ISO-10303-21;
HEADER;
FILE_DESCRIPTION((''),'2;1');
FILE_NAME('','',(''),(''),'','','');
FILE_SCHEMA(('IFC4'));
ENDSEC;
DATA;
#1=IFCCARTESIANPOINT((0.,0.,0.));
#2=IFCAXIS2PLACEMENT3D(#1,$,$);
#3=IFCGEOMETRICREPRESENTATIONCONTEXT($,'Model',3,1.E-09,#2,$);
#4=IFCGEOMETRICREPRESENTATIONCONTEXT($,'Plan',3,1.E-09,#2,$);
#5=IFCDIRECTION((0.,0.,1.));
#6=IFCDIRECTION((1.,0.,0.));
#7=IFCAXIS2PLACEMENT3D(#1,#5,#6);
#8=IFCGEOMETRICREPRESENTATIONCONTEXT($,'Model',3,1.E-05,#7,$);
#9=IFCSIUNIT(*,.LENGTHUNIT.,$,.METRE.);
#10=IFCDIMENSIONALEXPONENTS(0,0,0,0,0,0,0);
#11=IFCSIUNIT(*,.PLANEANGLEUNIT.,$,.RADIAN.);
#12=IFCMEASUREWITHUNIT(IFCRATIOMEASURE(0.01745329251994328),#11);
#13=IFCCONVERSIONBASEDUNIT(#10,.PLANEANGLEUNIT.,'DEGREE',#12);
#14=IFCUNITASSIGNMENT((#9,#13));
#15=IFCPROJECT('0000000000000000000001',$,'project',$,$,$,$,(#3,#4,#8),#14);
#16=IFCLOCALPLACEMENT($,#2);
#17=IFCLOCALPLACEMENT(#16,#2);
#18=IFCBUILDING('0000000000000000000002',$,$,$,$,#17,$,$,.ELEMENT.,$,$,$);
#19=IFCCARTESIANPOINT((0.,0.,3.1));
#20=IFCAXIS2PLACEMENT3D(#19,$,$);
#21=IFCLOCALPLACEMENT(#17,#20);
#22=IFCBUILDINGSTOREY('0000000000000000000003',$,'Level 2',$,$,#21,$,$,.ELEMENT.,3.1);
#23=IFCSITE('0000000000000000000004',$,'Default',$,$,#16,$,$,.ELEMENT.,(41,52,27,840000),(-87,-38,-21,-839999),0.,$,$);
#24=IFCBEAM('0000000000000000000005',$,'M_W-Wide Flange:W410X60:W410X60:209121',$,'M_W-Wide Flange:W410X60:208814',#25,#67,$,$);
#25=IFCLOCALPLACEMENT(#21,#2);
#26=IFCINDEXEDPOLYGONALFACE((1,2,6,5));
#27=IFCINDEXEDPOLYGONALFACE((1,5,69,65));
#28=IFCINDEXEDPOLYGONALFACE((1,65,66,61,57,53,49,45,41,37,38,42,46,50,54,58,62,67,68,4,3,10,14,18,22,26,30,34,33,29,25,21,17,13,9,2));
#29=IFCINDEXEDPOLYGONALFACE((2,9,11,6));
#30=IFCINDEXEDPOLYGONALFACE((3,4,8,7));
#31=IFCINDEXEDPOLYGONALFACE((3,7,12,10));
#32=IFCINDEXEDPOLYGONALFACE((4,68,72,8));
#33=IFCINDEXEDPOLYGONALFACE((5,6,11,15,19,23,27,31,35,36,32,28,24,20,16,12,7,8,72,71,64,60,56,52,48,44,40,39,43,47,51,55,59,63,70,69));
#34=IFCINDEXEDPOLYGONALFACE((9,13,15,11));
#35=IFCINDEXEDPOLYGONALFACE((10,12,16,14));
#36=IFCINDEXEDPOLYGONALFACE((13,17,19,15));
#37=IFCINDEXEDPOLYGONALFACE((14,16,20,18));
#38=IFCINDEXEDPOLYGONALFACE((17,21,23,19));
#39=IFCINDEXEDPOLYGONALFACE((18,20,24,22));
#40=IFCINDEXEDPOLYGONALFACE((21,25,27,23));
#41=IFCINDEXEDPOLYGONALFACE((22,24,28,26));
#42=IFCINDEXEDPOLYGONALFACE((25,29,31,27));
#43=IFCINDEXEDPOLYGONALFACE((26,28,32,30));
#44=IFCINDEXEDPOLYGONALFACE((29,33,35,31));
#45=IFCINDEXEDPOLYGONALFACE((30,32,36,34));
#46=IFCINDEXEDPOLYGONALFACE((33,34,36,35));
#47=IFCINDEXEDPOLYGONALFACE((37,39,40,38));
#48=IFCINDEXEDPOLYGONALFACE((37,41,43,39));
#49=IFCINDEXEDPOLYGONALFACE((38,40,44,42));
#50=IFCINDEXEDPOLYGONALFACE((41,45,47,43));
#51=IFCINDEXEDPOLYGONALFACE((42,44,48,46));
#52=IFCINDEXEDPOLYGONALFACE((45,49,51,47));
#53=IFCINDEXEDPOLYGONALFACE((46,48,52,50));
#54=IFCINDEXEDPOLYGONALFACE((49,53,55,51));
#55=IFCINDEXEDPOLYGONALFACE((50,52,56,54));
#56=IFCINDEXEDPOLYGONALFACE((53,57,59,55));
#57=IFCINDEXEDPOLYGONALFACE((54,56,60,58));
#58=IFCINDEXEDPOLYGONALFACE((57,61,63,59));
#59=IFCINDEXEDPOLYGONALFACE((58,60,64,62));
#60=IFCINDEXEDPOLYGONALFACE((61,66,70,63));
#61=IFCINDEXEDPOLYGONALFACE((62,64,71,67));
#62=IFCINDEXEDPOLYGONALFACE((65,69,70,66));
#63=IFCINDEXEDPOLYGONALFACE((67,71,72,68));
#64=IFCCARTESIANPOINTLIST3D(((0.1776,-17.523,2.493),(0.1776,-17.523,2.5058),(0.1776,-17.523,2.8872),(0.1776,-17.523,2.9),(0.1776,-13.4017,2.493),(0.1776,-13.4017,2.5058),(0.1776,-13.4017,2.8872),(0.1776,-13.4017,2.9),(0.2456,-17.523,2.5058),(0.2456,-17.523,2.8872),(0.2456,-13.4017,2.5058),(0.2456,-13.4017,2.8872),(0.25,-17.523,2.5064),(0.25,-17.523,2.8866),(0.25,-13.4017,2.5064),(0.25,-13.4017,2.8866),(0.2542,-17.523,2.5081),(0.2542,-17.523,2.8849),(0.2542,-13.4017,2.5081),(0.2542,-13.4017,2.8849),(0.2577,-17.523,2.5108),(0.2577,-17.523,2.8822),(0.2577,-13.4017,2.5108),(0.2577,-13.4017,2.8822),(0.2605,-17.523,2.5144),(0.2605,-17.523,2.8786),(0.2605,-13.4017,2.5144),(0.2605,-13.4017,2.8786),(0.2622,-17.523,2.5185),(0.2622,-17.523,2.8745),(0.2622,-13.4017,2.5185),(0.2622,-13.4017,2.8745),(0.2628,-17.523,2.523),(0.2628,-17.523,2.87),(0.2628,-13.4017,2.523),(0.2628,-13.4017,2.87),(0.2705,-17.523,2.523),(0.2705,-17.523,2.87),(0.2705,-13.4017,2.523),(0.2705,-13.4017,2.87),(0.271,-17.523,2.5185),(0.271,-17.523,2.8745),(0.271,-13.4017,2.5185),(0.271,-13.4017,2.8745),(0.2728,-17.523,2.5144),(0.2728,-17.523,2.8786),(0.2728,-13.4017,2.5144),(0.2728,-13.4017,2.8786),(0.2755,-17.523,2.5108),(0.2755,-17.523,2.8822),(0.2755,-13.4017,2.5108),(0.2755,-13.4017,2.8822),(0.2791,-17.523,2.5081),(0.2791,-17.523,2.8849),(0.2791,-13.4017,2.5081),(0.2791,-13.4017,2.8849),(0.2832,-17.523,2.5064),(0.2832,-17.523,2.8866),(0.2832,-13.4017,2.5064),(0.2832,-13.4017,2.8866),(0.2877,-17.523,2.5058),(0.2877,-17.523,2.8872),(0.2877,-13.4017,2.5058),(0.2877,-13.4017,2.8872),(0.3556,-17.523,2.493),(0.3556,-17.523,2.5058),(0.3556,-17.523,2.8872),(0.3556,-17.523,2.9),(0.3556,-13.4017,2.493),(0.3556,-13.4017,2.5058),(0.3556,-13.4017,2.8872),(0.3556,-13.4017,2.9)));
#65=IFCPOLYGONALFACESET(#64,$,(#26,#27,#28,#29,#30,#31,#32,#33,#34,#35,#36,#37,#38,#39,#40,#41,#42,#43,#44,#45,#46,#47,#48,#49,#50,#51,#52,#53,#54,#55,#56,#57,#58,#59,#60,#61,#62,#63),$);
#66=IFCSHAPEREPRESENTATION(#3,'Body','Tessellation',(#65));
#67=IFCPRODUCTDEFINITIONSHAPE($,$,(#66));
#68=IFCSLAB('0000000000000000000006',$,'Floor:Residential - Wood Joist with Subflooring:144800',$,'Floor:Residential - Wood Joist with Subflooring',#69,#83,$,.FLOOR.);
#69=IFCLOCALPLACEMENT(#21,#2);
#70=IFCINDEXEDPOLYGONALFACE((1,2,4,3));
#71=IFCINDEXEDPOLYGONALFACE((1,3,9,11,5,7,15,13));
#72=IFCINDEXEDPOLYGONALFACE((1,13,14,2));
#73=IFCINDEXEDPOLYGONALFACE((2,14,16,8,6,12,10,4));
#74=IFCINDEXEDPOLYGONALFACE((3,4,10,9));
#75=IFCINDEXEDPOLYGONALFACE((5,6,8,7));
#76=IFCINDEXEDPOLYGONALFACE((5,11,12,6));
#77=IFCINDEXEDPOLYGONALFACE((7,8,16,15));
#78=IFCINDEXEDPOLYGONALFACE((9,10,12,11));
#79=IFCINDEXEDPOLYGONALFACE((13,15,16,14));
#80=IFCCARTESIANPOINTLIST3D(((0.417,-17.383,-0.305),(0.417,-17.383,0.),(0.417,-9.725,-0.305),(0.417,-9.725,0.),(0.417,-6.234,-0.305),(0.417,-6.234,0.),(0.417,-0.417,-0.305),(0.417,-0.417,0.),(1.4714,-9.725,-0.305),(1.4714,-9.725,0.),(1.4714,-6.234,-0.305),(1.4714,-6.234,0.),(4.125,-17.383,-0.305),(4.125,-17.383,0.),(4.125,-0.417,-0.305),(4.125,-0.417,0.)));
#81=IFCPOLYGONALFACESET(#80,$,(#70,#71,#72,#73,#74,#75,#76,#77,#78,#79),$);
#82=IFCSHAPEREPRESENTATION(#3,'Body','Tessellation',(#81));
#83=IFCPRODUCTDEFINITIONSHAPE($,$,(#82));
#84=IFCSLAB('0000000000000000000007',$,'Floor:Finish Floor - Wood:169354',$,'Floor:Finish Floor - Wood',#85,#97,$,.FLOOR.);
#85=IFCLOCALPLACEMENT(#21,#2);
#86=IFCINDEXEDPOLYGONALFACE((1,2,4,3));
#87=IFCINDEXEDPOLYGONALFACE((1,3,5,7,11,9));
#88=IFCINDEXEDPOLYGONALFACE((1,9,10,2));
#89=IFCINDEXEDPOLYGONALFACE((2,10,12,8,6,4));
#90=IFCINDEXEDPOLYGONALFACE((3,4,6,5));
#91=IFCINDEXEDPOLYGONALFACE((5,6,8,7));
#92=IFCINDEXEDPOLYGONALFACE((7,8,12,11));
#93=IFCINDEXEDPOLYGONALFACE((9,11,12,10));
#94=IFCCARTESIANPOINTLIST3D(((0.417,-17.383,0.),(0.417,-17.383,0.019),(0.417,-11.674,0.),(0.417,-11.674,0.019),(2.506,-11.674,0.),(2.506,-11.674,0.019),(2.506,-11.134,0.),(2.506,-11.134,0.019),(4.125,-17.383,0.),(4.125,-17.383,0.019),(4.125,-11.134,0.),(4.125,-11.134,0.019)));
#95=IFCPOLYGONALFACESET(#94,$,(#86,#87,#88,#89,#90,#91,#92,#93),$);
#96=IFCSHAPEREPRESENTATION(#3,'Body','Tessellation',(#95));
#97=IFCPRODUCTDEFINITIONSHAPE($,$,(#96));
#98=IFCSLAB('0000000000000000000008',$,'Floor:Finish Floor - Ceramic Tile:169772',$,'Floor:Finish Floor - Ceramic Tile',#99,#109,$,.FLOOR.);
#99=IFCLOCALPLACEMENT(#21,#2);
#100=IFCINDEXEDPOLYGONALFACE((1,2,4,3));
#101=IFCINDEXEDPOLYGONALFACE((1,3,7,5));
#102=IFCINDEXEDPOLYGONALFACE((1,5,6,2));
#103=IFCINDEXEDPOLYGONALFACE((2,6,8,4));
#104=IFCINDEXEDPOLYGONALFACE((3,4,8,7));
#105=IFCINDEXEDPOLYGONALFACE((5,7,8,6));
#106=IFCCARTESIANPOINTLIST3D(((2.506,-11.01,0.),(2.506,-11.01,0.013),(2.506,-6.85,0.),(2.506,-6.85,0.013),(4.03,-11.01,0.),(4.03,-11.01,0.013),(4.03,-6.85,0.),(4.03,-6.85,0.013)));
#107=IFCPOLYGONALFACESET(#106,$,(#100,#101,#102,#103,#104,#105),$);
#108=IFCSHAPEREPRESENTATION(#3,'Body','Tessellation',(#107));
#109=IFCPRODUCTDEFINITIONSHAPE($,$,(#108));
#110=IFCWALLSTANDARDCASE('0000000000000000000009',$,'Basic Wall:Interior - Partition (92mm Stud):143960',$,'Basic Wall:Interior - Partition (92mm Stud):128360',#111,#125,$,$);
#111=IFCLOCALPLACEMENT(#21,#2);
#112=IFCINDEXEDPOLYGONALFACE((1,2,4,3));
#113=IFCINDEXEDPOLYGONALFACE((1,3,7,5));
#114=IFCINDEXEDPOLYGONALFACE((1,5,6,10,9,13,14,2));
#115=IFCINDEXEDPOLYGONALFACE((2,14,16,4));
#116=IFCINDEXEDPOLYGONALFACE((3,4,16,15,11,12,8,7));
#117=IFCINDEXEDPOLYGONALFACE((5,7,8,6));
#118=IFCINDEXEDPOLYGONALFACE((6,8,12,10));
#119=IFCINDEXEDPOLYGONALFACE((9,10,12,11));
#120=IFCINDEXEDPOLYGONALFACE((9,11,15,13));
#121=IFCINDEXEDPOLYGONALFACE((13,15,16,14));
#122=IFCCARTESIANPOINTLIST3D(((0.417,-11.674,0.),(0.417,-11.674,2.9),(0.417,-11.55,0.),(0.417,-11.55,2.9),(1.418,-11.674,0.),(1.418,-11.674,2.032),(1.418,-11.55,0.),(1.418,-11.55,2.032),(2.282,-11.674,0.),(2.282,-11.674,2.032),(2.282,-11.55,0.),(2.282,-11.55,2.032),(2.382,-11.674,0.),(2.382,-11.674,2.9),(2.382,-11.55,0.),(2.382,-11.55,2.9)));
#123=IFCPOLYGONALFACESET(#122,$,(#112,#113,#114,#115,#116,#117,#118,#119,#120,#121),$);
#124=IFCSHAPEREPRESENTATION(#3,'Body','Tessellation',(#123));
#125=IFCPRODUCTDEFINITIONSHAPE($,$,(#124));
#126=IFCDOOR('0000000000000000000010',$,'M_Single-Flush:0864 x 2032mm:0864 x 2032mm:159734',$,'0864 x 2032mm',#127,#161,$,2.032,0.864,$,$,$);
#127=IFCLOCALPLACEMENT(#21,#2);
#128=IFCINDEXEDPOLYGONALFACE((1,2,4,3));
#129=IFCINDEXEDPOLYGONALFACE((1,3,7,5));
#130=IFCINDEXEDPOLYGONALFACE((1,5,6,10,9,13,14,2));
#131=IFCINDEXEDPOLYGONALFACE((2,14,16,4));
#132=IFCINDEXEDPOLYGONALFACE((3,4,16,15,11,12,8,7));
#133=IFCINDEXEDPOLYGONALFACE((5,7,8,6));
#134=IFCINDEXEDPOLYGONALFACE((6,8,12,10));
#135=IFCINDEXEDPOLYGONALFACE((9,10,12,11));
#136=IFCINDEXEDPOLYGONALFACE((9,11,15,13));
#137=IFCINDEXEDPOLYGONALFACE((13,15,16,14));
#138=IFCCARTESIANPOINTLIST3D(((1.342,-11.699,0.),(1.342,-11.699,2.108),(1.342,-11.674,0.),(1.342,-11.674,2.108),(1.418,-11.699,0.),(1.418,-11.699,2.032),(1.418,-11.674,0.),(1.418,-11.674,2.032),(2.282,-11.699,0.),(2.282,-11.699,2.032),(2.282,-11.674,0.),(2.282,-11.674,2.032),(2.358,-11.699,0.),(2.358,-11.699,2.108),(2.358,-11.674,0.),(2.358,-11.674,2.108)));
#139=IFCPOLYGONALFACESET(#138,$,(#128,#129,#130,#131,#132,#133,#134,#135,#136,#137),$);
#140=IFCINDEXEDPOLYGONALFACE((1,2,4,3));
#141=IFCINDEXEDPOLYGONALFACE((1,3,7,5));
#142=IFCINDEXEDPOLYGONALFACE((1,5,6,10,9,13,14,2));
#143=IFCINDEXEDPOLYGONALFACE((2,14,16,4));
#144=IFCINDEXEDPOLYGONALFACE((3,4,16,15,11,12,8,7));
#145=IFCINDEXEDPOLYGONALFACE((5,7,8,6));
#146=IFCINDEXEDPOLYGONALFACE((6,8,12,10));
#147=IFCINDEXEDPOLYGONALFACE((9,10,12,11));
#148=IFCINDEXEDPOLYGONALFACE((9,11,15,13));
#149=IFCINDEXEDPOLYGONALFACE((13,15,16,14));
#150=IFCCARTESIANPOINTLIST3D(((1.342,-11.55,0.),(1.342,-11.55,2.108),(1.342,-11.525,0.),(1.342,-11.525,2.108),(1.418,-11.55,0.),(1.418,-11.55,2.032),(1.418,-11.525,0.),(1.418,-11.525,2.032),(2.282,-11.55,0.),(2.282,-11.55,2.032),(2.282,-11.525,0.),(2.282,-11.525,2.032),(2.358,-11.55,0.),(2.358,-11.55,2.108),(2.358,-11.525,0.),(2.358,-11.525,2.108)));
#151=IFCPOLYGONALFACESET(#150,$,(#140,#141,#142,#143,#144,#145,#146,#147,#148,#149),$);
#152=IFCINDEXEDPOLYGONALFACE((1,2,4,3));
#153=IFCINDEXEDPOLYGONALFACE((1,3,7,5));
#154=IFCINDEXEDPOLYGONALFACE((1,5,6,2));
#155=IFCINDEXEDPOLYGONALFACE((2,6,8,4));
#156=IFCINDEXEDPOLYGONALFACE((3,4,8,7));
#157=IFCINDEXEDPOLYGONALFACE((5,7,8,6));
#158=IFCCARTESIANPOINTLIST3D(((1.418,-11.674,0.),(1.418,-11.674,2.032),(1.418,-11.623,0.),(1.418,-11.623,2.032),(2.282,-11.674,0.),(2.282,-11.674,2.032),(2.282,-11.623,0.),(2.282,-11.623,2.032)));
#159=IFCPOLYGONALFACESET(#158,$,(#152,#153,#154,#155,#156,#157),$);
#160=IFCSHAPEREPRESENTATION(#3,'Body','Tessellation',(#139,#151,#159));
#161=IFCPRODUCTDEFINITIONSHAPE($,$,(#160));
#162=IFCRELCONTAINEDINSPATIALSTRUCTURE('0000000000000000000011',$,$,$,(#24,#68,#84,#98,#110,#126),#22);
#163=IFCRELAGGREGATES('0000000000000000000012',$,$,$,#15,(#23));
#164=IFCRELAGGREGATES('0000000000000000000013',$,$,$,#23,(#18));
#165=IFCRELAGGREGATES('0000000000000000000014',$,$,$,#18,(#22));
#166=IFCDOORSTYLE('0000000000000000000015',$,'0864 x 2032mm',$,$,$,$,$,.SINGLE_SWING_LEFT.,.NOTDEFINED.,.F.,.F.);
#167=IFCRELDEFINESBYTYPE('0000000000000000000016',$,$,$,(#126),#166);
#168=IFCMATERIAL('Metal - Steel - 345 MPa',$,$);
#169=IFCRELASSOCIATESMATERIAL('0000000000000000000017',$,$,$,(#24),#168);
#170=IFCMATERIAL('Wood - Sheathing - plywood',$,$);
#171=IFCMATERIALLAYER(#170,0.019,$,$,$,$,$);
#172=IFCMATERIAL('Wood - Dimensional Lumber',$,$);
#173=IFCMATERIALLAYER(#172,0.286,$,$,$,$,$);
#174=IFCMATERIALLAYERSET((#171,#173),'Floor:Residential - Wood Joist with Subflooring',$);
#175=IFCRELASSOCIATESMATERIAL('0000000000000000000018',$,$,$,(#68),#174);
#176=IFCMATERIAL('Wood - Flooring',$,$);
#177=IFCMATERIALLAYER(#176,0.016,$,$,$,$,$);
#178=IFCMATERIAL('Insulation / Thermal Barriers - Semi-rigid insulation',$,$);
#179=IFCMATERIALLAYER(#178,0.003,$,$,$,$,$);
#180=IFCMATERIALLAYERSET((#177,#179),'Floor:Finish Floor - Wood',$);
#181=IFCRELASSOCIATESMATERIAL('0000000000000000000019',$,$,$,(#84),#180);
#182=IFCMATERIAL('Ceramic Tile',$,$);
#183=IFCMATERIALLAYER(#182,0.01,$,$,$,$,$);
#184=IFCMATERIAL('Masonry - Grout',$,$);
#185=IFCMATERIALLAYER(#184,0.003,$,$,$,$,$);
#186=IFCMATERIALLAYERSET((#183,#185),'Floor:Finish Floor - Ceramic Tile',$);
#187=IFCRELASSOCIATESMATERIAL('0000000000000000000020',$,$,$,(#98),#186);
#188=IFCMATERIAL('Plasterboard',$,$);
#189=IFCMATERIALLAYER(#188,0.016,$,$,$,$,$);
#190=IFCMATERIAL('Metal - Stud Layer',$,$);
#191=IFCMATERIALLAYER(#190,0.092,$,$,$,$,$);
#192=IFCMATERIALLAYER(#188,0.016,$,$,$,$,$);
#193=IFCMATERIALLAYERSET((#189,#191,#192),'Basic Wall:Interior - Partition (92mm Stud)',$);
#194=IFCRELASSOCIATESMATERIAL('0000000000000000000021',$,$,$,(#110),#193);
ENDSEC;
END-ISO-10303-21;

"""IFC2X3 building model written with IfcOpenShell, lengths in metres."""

from ifc_helpers import new_model, entity, si_unit, converted_unit, frame, frame_2d, origin, origin_with_axes, origin_2d_with_axis, place, context, project, spatial, polyline, circle_curve, parameter, trimmed, segment, composite_curve, rectangle, outline, extrude, source, transform, mapped, material, layer, layer_set, layer_usage, type_object, type_shapes, element, fill, save


model = new_model("IFC2X3")

# Units and contexts
model_context_1 = context("Model", 3, precision=1e-09, world=origin())
plan_context = context("Plan", 3, precision=1e-09, world=origin())
model_context_2 = context("Model", 3, precision=1e-05, world=origin_with_axes())
ifc_project = project(units=[si_unit("LENGTHUNIT", "METRE"), converted_unit("PLANEANGLEUNIT", "DEGREE", entity("IfcRatioMeasure", 0.01745329251994328), si_unit("PLANEANGLEUNIT", "RADIAN"), dimensions=[0, 0, 0, 0, 0, 0, 0])], contexts=[model_context_1, plan_context, model_context_2])

# Site, building, storey
site_placement = place(None, origin())
site = spatial("IfcSite", under=ifc_project, at=site_placement, Name="Default", CompositionType="ELEMENT", RefLatitude=(41, 52, 27, 840000), RefLongitude=(-87, -38, -21, -839999), RefElevation=0.0)
building_placement = place(site_placement, origin())
building = spatial("IfcBuilding", under=site, at=building_placement, CompositionType="ELEMENT")
storey_placement = place(building_placement, frame((0.0, 0.0, 3.1)))
storey = spatial("IfcBuildingStorey", under=building, at=storey_placement, Name="Level 2", CompositionType="ELEMENT", Elevation=3.1)

# Beam
ifc_material_1 = material(Name="Metal - Steel - 345 MPa")
beam_placement = place(storey_placement, frame((0.2666, -13.4017, 2.9), z_axis=(0.0, 0.0, 1.0), x_axis=(-1.0, 0.0, 0.0)))
element("IfcBeam", 1, at=beam_placement, inside=storey, material=ifc_material_1, Name="M_W-Wide Flange:W410X60:W410X60:209121", ObjectType="M_W-Wide Flange:W410X60:208814", context=model_context_1, shape_type="SweptSolid", body=[
    extrude(outline(composite_curve([segment(polyline([(0.1907, -0.089), (0.2035, -0.089)]), True, "CONTINUOUS"), segment(polyline([(0.2035, -0.089), (0.2035, 0.089)]), True, "CONTINUOUS"), segment(polyline([(0.2035, 0.089), (0.1907, 0.089)]), True, "CONTINUOUS"), segment(polyline([(0.1907, 0.089), (0.1907, 0.021)]), True, "CONTINUOUS"), segment(trimmed(circle_curve(frame_2d((0.1735, 0.021), x_axis=(1.0, 0.0)), 0.0172), [parameter(270.0)], [parameter(360.0)], True, "PARAMETER"), False, "CONTINUOUS"), segment(polyline([(0.1735, 0.0038), (-0.1735, 0.0038)]), True, "CONTINUOUS"), segment(trimmed(circle_curve(frame_2d((-0.1735, 0.021), x_axis=(0.0, -1.0)), 0.0172), [parameter(270.0)], [parameter(360.0)], True, "PARAMETER"), False, "CONTINUOUS"), segment(polyline([(-0.1907, 0.021), (-0.1907, 0.089)]), True, "CONTINUOUS"), segment(polyline([(-0.1907, 0.089), (-0.2035, 0.089)]), True, "CONTINUOUS"), segment(polyline([(-0.2035, 0.089), (-0.2035, -0.089)]), True, "CONTINUOUS"), segment(polyline([(-0.2035, -0.089), (-0.1907, -0.089)]), True, "CONTINUOUS"), segment(polyline([(-0.1907, -0.089), (-0.1907, -0.0211)]), True, "CONTINUOUS"), segment(trimmed(circle_curve(frame_2d((-0.1735, -0.0211), x_axis=(-1.0, 0.0)), 0.0172), [parameter(270.0)], [parameter(0.0)], True, "PARAMETER"), False, "CONTINUOUS"), segment(polyline([(-0.1735, -0.0039), (0.1735, -0.0039)]), True, "CONTINUOUS"), segment(trimmed(circle_curve(frame_2d((0.1735, -0.0211), x_axis=(0.0, 1.0)), 0.0172), [parameter(270.0)], [parameter(0.0)], True, "PARAMETER"), False, "CONTINUOUS"), segment(polyline([(0.1907, -0.0211), (0.1907, -0.089)]), True, "CONTINUOUS")], self_intersect=False)), frame((0.0, 4.1213, -0.2035), z_axis=(0.0, -1.0, 0.0), x_axis=(0.0, 0.0, -1.0)), (0.0, 0.0, 1.0), 4.1213),
])

# Slabs
ifc_material_2 = material(Name="Wood - Sheathing - plywood")
ifc_layer_1 = layer(ifc_material_2, 0.019)
ifc_material_3 = material(Name="Wood - Dimensional Lumber")
ifc_layer_2 = layer(ifc_material_3, 0.286)
ifc_layer_set_1 = layer_set([ifc_layer_1, ifc_layer_2], Name="Floor:Residential - Wood Joist with Subflooring")
ifc_layer_usage_1 = layer_usage(ifc_layer_set_1, "AXIS3", "POSITIVE", 0.0)
slab_1_placement = place(storey_placement, frame((0.417, -17.383, -0.305)))
element("IfcSlab", 2, at=slab_1_placement, inside=storey, material=ifc_layer_usage_1, Name="Floor:Residential - Wood Joist with Subflooring:144800", ObjectType="Floor:Residential - Wood Joist with Subflooring", PredefinedType="FLOOR", context=model_context_1, shape_type="SweptSolid", body=[
    extrude(outline(polyline([(-1.854, 8.483), (-1.854, -8.483), (1.854, -8.483), (1.854, -0.825), (0.7996, -0.825), (0.7996, 2.666), (1.854, 2.666), (1.854, 8.483), (-1.854, 8.483)])), frame((1.854, 8.483, 0.305), z_axis=(0.0, 0.0, -1.0), x_axis=(-1.0, 0.0, 0.0)), (0.0, 0.0, 1.0), 0.305),
])
ifc_material_4 = material(Name="Wood - Flooring")
ifc_layer_3 = layer(ifc_material_4, 0.016)
ifc_material_5 = material(Name="Insulation / Thermal Barriers - Semi-rigid insulation")
ifc_layer_4 = layer(ifc_material_5, 0.003)
ifc_layer_set_2 = layer_set([ifc_layer_3, ifc_layer_4], Name="Floor:Finish Floor - Wood")
ifc_layer_usage_2 = layer_usage(ifc_layer_set_2, "AXIS3", "POSITIVE", 0.0)
slab_2_placement = place(storey_placement, frame((0.417, -17.383, 0.0)))
element("IfcSlab", 3, at=slab_2_placement, inside=storey, material=ifc_layer_usage_2, Name="Floor:Finish Floor - Wood:169354", ObjectType="Floor:Finish Floor - Wood", PredefinedType="FLOOR", context=model_context_1, shape_type="SweptSolid", body=[
    extrude(outline(polyline([(-1.854, -3.1245), (1.854, -3.1245), (1.854, 2.5845), (-0.235, 2.5845), (-0.235, 3.1245), (-1.854, 3.1245), (-1.854, -3.1245)])), frame((1.854, 3.1245, 0.019), z_axis=(0.0, 0.0, -1.0), x_axis=(-1.0, 0.0, 0.0)), (0.0, 0.0, 1.0), 0.019),
])
ifc_material_6 = material(Name="Ceramic Tile")
ifc_layer_5 = layer(ifc_material_6, 0.01)
ifc_material_7 = material(Name="Masonry - Grout")
ifc_layer_6 = layer(ifc_material_7, 0.003)
ifc_layer_set_3 = layer_set([ifc_layer_5, ifc_layer_6], Name="Floor:Finish Floor - Ceramic Tile")
ifc_layer_usage_3 = layer_usage(ifc_layer_set_3, "AXIS3", "POSITIVE", 0.0)
slab_3_placement = place(storey_placement, frame((2.506, -11.01, 0.0)))
element("IfcSlab", 4, at=slab_3_placement, inside=storey, material=ifc_layer_usage_3, Name="Floor:Finish Floor - Ceramic Tile:169772", ObjectType="Floor:Finish Floor - Ceramic Tile", PredefinedType="FLOOR", context=model_context_1, shape_type="SweptSolid", body=[
    extrude(rectangle(XDim=4.16, YDim=1.524, at=frame_2d((0.0, 0.0), x_axis=(0.0, -1.0))), frame((0.762, 2.08, 0.013), z_axis=(0.0, 0.0, -1.0), x_axis=(-1.0, 0.0, 0.0)), (0.0, 0.0, 1.0), 0.013),
])

# Shared definitions
ifc_material_8 = material(Name="Metal - Stud Layer")
ifc_material_9 = material(Name="Plasterboard")

# Wall, opening, door
ifc_layer_7 = layer(ifc_material_9, 0.016)
ifc_layer_8 = layer(ifc_material_8, 0.092)
ifc_layer_9 = layer(ifc_material_9, 0.016)
ifc_layer_set_4 = layer_set([ifc_layer_7, ifc_layer_8, ifc_layer_9], Name="Basic Wall:Interior - Partition (92mm Stud)")
ifc_layer_usage_4 = layer_usage(ifc_layer_set_4, "AXIS2", "NEGATIVE", 0.062)
wall_1_placement = place(storey_placement, frame((2.382, -11.612, 0.0), z_axis=(0.0, 0.0, 1.0), x_axis=(-1.0, 0.0, 0.0)))
wall_1 = element("IfcWallStandardCase", 5, at=wall_1_placement, inside=storey, material=ifc_layer_usage_4, Name="Basic Wall:Interior - Partition (92mm Stud):143960", ObjectType="Basic Wall:Interior - Partition (92mm Stud):128360", context=model_context_1, shape_type="SweptSolid", body=[
    extrude(rectangle(XDim=1.965, YDim=0.124, at=frame_2d((0.9825, 0.0), x_axis=(-1.0, 0.0))), origin(), (0.0, 0.0, 1.0), 2.9),
])
opening_1_placement = place(wall_1_placement, frame((0.1, -0.062, 0.0)))
opening_1 = element("IfcOpeningElement", 6, at=opening_1_placement, cuts=wall_1, ObjectType="Opening", context=model_context_1, shape_type="SweptSolid", body=[
    extrude(rectangle(XDim=0.864, YDim=2.032, at=frame_2d((1.016, 0.432), x_axis=(0.0, -1.0))), frame((0.0, 0.0, 0.0), z_axis=(0.0, 1.0, 0.0), x_axis=(0.0, 0.0, 1.0)), (0.0, 0.0, 1.0), 0.124),
])
door_style = type_object("IfcDoorStyle", Name="0864 x 2032mm", ConstructionType="NOTDEFINED", OperationType="SINGLE_SWING_LEFT", ParameterTakesPrecedence=False, Sizeable=False)
shared_shape_1 = source(origin(), model_context_1, "Body", "SweptSolid", [
    extrude(outline(polyline([(-0.508, -1.073), (0.508, -1.073), (0.508, 1.035), (0.432, 1.035), (0.432, -0.997), (-0.432, -0.997), (-0.432, 1.035), (-0.508, 1.035), (-0.508, -1.073)])), frame((0.432, 0.149, 1.035), z_axis=(0.0, -1.0, 0.0), x_axis=(-1.0, 0.0, 0.0)), (0.0, 0.0, 1.0), 0.025),
    extrude(outline(polyline([(-1.073, -0.508), (1.035, -0.508), (1.035, -0.432), (-0.997, -0.432), (-0.997, 0.432), (1.035, 0.432), (1.035, 0.508), (-1.073, 0.508), (-1.073, -0.508)])), frame((0.432, 0.0, 1.035), z_axis=(0.0, -1.0, 0.0), x_axis=(0.0, 0.0, -1.0)), (0.0, 0.0, 1.0), 0.025),
    extrude(rectangle(XDim=0.864, YDim=0.051, at=origin_2d_with_axis()), frame((0.432, 0.0985, 0.0)), (0.0, 0.0, 1.0), 2.032),
])
type_shapes(door_style, [shared_shape_1])
door_placement = place(opening_1_placement, origin())
door = element("IfcDoor", 7, at=door_placement, inside=storey, type_object=door_style, Name="M_Single-Flush:0864 x 2032mm:0864 x 2032mm:159734", ObjectType="0864 x 2032mm", OverallHeight=2.032, OverallWidth=0.864, context=model_context_1, shape_type="MappedRepresentation", body=[
    mapped(shared_shape_1, transform((0.0, 0.0, 0.0), scale=1.0)),
])
fill(opening_1, door)

save(model, "model.ifc")
